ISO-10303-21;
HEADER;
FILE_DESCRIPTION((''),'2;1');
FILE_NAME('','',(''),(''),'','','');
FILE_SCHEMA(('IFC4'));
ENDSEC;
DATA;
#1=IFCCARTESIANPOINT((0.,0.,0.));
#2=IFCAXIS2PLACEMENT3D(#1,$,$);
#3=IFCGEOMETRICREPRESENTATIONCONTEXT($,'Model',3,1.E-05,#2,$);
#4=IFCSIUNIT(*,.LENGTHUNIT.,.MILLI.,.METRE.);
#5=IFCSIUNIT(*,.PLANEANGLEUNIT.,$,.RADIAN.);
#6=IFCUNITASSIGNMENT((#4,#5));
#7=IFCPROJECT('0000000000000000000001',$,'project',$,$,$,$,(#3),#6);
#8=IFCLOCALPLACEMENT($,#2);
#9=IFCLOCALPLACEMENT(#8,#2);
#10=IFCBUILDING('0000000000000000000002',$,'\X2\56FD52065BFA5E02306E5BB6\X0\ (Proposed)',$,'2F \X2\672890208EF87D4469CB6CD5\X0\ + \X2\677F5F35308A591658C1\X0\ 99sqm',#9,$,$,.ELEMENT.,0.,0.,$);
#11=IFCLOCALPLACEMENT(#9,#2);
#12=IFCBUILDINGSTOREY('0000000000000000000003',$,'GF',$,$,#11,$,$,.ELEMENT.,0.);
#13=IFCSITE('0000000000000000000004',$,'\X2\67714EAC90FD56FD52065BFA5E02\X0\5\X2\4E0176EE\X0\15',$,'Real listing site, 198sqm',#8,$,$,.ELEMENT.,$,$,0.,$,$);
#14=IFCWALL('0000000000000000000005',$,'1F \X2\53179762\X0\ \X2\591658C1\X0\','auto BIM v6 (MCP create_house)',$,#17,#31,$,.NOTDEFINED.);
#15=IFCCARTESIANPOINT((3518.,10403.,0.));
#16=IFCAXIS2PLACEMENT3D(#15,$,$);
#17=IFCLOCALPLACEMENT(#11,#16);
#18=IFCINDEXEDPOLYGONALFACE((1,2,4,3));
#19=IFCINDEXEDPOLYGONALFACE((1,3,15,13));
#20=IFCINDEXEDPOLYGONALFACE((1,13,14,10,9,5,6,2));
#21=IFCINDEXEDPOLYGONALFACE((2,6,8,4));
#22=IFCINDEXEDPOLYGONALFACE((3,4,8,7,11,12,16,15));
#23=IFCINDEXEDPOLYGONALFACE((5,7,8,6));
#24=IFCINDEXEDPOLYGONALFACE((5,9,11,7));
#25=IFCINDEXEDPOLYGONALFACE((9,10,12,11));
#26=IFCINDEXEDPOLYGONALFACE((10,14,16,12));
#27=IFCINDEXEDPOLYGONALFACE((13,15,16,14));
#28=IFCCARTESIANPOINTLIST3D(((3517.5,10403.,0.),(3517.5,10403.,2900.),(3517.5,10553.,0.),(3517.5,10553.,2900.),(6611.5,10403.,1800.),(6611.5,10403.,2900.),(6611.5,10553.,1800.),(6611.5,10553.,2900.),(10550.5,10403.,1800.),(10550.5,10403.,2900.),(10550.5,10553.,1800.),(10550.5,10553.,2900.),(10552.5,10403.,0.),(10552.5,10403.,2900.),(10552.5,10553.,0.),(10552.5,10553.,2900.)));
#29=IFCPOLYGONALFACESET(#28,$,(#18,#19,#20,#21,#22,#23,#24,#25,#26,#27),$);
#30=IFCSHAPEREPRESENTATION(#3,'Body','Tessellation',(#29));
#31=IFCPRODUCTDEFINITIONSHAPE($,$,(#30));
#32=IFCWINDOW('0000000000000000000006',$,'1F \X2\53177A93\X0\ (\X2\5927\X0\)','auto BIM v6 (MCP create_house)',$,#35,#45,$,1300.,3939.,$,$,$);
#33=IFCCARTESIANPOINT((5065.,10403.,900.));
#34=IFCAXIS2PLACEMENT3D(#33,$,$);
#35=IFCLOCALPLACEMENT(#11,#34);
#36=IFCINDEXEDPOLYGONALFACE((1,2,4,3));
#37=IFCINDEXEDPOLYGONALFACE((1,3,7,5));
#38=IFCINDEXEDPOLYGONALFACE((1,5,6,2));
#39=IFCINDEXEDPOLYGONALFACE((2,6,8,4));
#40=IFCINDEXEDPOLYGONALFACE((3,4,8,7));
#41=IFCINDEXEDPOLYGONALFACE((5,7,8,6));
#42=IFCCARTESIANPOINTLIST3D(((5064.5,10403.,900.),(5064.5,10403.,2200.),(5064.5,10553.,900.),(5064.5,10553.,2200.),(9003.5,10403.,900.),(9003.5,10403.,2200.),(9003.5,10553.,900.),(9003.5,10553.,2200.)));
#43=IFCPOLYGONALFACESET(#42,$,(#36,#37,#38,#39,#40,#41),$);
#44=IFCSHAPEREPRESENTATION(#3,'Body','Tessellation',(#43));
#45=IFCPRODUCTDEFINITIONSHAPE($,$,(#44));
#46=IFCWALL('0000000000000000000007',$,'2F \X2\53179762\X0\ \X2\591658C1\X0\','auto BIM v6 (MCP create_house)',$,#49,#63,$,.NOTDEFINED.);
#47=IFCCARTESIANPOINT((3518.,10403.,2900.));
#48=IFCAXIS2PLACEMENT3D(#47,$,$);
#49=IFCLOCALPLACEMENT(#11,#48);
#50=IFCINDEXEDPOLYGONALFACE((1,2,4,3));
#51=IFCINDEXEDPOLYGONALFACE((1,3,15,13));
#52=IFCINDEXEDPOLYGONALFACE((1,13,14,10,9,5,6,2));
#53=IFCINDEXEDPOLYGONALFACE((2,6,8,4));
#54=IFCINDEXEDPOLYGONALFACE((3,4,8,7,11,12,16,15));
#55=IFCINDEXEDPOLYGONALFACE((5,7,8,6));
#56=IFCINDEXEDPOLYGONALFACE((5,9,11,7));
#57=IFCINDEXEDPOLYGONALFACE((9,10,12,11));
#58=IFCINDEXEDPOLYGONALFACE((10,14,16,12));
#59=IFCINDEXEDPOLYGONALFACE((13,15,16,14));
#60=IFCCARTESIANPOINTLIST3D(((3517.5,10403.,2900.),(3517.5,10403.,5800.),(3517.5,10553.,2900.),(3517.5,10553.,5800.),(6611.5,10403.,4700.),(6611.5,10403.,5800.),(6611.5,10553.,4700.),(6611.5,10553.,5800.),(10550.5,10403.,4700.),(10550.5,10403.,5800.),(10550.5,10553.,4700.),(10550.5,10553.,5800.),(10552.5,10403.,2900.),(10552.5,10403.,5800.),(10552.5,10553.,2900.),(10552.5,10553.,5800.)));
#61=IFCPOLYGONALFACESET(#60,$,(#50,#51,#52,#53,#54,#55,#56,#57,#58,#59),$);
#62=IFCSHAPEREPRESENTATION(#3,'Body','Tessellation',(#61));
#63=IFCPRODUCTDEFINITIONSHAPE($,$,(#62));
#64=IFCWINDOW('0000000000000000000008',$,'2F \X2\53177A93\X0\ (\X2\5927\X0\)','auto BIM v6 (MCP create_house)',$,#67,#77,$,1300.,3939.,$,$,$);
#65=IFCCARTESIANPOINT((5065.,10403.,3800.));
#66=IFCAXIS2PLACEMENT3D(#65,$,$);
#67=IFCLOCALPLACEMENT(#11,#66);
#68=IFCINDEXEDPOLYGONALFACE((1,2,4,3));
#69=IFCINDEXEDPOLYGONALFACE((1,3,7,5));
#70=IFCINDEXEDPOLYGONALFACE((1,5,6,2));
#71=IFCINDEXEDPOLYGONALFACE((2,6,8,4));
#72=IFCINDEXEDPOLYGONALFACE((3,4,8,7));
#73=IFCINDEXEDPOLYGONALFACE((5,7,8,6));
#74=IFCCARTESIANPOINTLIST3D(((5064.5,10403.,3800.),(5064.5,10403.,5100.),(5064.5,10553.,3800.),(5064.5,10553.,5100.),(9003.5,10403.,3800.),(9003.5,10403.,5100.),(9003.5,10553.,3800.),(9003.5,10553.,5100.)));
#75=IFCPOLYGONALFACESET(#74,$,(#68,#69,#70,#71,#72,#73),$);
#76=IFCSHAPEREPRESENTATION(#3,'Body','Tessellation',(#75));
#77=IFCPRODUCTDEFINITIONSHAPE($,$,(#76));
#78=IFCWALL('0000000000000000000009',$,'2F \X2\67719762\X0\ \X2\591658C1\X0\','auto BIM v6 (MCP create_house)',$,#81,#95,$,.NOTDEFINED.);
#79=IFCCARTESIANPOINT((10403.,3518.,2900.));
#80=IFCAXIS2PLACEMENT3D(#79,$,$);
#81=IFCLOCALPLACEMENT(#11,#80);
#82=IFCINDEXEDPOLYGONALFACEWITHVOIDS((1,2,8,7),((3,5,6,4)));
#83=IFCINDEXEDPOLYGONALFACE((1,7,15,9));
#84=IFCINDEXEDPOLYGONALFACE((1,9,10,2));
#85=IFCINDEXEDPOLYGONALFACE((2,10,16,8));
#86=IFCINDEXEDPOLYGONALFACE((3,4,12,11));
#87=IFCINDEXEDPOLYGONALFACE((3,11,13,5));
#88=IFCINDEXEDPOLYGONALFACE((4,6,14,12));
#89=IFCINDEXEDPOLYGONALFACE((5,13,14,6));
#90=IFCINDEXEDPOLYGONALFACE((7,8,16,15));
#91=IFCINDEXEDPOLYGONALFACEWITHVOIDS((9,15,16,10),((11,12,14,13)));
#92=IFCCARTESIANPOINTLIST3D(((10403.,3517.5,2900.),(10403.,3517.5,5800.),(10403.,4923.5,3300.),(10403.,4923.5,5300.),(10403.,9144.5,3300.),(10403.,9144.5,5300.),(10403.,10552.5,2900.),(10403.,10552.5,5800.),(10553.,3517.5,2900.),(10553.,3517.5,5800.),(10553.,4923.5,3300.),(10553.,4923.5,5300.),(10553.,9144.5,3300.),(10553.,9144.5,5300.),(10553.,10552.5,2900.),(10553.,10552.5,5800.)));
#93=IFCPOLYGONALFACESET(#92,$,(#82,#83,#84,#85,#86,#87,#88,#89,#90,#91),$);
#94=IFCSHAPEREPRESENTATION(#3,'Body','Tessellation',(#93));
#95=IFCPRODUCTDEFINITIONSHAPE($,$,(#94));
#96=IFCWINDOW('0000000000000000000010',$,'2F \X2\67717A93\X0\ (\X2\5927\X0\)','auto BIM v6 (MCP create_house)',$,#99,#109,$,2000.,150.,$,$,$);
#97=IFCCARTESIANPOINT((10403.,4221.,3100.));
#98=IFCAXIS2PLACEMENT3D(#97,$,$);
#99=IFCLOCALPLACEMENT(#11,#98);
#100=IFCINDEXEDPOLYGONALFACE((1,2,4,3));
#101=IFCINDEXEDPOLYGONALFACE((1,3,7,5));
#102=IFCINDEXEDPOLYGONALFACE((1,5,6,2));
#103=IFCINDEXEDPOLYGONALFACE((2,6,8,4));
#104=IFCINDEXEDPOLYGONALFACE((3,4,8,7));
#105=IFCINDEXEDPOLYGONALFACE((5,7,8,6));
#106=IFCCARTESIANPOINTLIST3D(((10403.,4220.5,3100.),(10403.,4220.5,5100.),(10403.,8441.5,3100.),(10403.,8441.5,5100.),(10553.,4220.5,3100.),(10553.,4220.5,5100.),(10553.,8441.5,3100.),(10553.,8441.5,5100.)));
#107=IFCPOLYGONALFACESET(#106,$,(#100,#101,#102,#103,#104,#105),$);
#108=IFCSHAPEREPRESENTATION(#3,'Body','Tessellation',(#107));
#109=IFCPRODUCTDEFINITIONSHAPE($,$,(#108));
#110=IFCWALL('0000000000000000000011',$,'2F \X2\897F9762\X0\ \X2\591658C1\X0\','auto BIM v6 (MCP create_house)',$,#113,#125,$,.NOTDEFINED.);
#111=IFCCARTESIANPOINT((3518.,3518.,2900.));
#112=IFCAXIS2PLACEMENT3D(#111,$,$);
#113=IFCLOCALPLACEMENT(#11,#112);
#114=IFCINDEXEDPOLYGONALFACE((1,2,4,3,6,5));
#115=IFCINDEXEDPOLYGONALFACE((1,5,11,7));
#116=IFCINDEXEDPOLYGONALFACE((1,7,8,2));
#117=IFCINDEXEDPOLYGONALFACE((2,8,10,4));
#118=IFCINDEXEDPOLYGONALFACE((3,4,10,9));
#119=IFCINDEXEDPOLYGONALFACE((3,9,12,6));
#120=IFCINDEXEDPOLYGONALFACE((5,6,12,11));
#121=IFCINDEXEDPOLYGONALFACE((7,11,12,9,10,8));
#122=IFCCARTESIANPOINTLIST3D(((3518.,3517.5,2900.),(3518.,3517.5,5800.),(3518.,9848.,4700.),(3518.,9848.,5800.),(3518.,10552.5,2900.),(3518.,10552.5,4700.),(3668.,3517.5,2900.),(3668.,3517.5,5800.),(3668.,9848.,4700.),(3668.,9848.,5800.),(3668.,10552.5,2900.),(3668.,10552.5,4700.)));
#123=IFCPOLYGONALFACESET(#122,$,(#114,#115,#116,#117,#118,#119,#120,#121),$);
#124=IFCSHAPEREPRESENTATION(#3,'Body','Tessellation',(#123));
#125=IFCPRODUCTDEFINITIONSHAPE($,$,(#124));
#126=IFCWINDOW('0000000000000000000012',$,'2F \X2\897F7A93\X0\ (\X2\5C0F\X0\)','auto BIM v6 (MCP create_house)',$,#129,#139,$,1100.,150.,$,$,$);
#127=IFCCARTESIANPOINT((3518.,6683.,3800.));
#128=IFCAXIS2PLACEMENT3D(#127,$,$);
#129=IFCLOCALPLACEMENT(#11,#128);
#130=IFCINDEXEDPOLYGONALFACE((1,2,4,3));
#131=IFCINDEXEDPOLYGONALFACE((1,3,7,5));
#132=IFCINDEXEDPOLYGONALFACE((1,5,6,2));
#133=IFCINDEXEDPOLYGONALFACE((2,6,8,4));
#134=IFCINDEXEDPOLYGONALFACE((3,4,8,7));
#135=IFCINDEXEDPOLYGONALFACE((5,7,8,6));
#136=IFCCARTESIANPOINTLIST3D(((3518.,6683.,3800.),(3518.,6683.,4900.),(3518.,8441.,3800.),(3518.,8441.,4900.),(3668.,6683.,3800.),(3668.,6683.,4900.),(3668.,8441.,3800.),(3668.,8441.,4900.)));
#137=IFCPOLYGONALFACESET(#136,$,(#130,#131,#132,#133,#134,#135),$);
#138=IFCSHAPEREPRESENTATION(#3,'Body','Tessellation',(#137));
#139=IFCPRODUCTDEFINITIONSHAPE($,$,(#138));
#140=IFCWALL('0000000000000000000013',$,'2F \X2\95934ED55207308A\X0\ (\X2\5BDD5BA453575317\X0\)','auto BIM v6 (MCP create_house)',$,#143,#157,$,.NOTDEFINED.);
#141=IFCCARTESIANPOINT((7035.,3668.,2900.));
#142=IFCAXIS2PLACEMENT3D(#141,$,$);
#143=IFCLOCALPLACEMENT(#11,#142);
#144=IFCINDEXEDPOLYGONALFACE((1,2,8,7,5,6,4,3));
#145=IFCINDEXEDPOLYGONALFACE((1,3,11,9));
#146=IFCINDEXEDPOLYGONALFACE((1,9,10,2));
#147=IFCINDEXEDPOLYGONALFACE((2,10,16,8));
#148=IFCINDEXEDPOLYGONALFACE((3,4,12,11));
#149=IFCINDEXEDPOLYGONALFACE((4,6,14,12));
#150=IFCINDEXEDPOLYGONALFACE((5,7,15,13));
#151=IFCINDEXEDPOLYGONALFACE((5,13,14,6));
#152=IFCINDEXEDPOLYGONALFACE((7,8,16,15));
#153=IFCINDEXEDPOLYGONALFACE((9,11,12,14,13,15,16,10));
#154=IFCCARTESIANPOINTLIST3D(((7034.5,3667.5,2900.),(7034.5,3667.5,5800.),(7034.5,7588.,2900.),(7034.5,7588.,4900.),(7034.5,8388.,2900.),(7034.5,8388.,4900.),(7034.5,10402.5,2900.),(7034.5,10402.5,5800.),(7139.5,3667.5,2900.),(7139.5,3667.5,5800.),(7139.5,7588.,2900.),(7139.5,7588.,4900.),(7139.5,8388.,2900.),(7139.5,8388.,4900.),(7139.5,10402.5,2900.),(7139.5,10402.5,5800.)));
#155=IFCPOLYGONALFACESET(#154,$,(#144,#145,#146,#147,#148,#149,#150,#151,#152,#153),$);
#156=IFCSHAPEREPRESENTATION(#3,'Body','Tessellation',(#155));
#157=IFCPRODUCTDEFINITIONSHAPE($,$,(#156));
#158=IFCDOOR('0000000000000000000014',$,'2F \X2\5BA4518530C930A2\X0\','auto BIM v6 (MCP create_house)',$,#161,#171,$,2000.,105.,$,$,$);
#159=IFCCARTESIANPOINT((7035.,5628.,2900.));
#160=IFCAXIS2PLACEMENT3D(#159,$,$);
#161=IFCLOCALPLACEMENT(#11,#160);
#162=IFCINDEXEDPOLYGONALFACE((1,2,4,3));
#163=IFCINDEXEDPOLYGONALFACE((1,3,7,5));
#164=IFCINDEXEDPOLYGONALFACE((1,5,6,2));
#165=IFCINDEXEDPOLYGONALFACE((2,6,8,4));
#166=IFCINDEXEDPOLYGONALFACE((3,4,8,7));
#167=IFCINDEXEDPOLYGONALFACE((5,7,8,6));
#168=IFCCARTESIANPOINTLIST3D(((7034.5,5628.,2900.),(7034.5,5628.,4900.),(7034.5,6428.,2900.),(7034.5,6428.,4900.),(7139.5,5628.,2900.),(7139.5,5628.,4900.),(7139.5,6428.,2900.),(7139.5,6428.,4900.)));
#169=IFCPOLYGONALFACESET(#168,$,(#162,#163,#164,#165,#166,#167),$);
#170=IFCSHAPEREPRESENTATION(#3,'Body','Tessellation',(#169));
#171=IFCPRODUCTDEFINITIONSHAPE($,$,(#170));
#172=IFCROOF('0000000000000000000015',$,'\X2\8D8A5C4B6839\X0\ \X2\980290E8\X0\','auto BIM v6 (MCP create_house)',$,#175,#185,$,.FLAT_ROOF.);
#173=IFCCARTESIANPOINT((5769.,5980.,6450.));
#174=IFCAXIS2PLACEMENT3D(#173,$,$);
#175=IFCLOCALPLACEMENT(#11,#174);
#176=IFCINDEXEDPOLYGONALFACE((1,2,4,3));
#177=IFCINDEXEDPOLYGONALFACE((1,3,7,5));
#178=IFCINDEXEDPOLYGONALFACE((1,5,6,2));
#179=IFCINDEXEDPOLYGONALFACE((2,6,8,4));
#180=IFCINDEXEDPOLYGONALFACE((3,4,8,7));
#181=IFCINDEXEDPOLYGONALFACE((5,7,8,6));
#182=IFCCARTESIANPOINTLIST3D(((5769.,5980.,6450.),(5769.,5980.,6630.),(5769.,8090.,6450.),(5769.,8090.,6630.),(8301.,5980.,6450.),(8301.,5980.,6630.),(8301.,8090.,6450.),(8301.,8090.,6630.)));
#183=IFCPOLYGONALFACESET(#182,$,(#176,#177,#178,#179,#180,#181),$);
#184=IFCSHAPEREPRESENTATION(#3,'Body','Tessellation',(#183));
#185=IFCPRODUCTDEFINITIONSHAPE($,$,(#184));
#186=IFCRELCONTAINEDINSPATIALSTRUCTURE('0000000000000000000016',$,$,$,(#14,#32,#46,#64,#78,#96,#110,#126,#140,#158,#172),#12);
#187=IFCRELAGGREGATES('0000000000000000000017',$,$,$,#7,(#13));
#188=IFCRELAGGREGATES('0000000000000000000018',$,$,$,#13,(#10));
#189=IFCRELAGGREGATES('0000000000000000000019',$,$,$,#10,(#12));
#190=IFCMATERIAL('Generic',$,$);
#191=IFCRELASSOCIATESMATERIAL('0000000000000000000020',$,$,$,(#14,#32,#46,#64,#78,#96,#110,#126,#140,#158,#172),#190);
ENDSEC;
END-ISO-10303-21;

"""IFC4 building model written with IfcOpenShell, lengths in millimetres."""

from ifc_helpers import new_model, si_unit, frame, frame_2d, origin, place, context, project, spatial, rectangle, extrude, material, element, fill, save


model = new_model("IFC4")

# Units and contexts
model_context = context("Model", 3, precision=1e-05, world=origin())
ifc_project = project(units=[si_unit("LENGTHUNIT", "METRE", prefix="MILLI"), si_unit("PLANEANGLEUNIT", "RADIAN")], contexts=[model_context])

# Site, building, storey
site_placement = place(None, origin())
site = spatial("IfcSite", under=ifc_project, at=site_placement, Name="東京都国分寺市5丁目15", ObjectType="Real listing site, 198sqm", CompositionType="ELEMENT", RefElevation=0.0)
building_placement = place(site_placement, origin())
building = spatial("IfcBuilding", under=site, at=building_placement, Name="国分寺市の家 (Proposed)", ObjectType="2F 木造軸組構法 + 板張り外壁 99sqm", CompositionType="ELEMENT", ElevationOfRefHeight=0.0, ElevationOfTerrain=0.0)
storey_placement = place(building_placement, origin())
storey = spatial("IfcBuildingStorey", under=building, at=storey_placement, Name="GF", CompositionType="ELEMENT", Elevation=0.0)

# Wall, opening, window
ifc_material = material(Name="Generic")
wall_1_placement = place(storey_placement, frame((3518.0, 10403.0, 0.0)))
wall_1 = element("IfcWall", 1, at=wall_1_placement, inside=storey, material=ifc_material, Name="1F 北面 外壁", Description="auto BIM v6 (MCP create_house)", PredefinedType="NOTDEFINED", context=model_context, shape_type="SweptSolid", body=[
    extrude(rectangle(XDim=7035.0, YDim=150.0, at=frame_2d((3517.0, 75.0))), frame((3518.0, 10403.0, 0.0)), (0.0, 0.0, 1.0), 2900.0),
])
opening_1_placement = place(storey_placement, frame((5065.0, 10403.0, 900.0)))
opening_1 = element("IfcOpeningElement", 2, at=opening_1_placement, cuts=wall_1, PredefinedType="NOTDEFINED", context=model_context, shape_type="SweptSolid", body=[
    extrude(rectangle(XDim=3939.0, YDim=150.0, at=frame_2d((1969.0, 75.0))), frame((5065.0, 10403.0, 900.0)), (0.0, 0.0, 1.0), 1300.0),
])
window_1_placement = place(storey_placement, frame((5065.0, 10403.0, 900.0)))
window_1 = element("IfcWindow", 3, at=window_1_placement, inside=storey, material=ifc_material, Name="1F 北窓 (大)", Description="auto BIM v6 (MCP create_house)", OverallHeight=1300.0, OverallWidth=3939.0, context=model_context, shape_type="SweptSolid", body=[
    extrude(rectangle(XDim=3939.0, YDim=150.0, at=frame_2d((1969.0, 75.0))), frame((5065.0, 10403.0, 900.0)), (0.0, 0.0, 1.0), 1300.0),
])
fill(opening_1, window_1)

# Walls, openings, windows
wall_2_placement = place(storey_placement, frame((3518.0, 10403.0, 2900.0)))
wall_2 = element("IfcWall", 4, at=wall_2_placement, inside=storey, material=ifc_material, Name="2F 北面 外壁", Description="auto BIM v6 (MCP create_house)", PredefinedType="NOTDEFINED", context=model_context, shape_type="SweptSolid", body=[
    extrude(rectangle(XDim=7035.0, YDim=150.0, at=frame_2d((3517.0, 75.0))), frame((3518.0, 10403.0, 2900.0)), (0.0, 0.0, 1.0), 2900.0),
])
opening_2_placement = place(storey_placement, frame((5065.0, 10403.0, 3800.0)))
opening_2 = element("IfcOpeningElement", 5, at=opening_2_placement, cuts=wall_2, PredefinedType="NOTDEFINED", context=model_context, shape_type="SweptSolid", body=[
    extrude(rectangle(XDim=3939.0, YDim=150.0, at=frame_2d((1969.0, 75.0))), frame((5065.0, 10403.0, 3800.0)), (0.0, 0.0, 1.0), 1300.0),
])
window_2_placement = place(storey_placement, frame((5065.0, 10403.0, 3800.0)))
window_2 = element("IfcWindow", 6, at=window_2_placement, inside=storey, material=ifc_material, Name="2F 北窓 (大)", Description="auto BIM v6 (MCP create_house)", OverallHeight=1300.0, OverallWidth=3939.0, context=model_context, shape_type="SweptSolid", body=[
    extrude(rectangle(XDim=3939.0, YDim=150.0, at=frame_2d((1969.0, 75.0))), frame((5065.0, 10403.0, 3800.0)), (0.0, 0.0, 1.0), 1300.0),
])
fill(opening_2, window_2)
wall_3_placement = place(storey_placement, frame((10403.0, 3518.0, 2900.0)))
wall_3 = element("IfcWall", 7, at=wall_3_placement, inside=storey, material=ifc_material, Name="2F 東面 外壁", Description="auto BIM v6 (MCP create_house)", PredefinedType="NOTDEFINED", context=model_context, shape_type="SweptSolid", body=[
    extrude(rectangle(XDim=150.0, YDim=7035.0, at=frame_2d((75.0, 3517.0))), frame((10403.0, 3518.0, 2900.0)), (0.0, 0.0, 1.0), 2900.0),
])
opening_3_placement = place(storey_placement, frame((10403.0, 4221.0, 3100.0)))
opening_3 = element("IfcOpeningElement", 8, at=opening_3_placement, cuts=wall_3, PredefinedType="NOTDEFINED", context=model_context, shape_type="SweptSolid", body=[
    extrude(rectangle(XDim=150.0, YDim=4221.0, at=frame_2d((75.0, 2110.0))), frame((10403.0, 4221.0, 3100.0)), (0.0, 0.0, 1.0), 2000.0),
])
window_3_placement = place(storey_placement, frame((10403.0, 4221.0, 3100.0)))
window_3 = element("IfcWindow", 9, at=window_3_placement, inside=storey, material=ifc_material, Name="2F 東窓 (大)", Description="auto BIM v6 (MCP create_house)", OverallHeight=2000.0, OverallWidth=150.0, context=model_context, shape_type="SweptSolid", body=[
    extrude(rectangle(XDim=150.0, YDim=4221.0, at=frame_2d((75.0, 2110.0))), frame((10403.0, 4221.0, 3100.0)), (0.0, 0.0, 1.0), 2000.0),
])
fill(opening_3, window_3)
wall_4_placement = place(storey_placement, frame((3518.0, 3518.0, 2900.0)))
wall_4 = element("IfcWall", 10, at=wall_4_placement, inside=storey, material=ifc_material, Name="2F 西面 外壁", Description="auto BIM v6 (MCP create_house)", PredefinedType="NOTDEFINED", context=model_context, shape_type="SweptSolid", body=[
    extrude(rectangle(XDim=150.0, YDim=7035.0, at=frame_2d((75.0, 3517.0))), frame((3518.0, 3518.0, 2900.0)), (0.0, 0.0, 1.0), 2900.0),
])
opening_4_placement = place(storey_placement, frame((3518.0, 6683.0, 3800.0)))
opening_4 = element("IfcOpeningElement", 11, at=opening_4_placement, cuts=wall_4, PredefinedType="NOTDEFINED", context=model_context, shape_type="SweptSolid", body=[
    extrude(rectangle(XDim=150.0, YDim=1758.0, at=frame_2d((75.0, 879.0))), frame((3518.0, 6683.0, 3800.0)), (0.0, 0.0, 1.0), 1100.0),
])
window_4_placement = place(storey_placement, frame((3518.0, 6683.0, 3800.0)))
window_4 = element("IfcWindow", 12, at=window_4_placement, inside=storey, material=ifc_material, Name="2F 西窓 (小)", Description="auto BIM v6 (MCP create_house)", OverallHeight=1100.0, OverallWidth=150.0, context=model_context, shape_type="SweptSolid", body=[
    extrude(rectangle(XDim=150.0, YDim=1758.0, at=frame_2d((75.0, 879.0))), frame((3518.0, 6683.0, 3800.0)), (0.0, 0.0, 1.0), 1100.0),
])
fill(opening_4, window_4)

# Wall, opening, door
wall_5_placement = place(storey_placement, frame((7035.0, 3668.0, 2900.0)))
wall_5 = element("IfcWall", 13, at=wall_5_placement, inside=storey, material=ifc_material, Name="2F 間仕切り (寝室南北)", Description="auto BIM v6 (MCP create_house)", PredefinedType="NOTDEFINED", context=model_context, shape_type="SweptSolid", body=[
    extrude(rectangle(XDim=105.0, YDim=6735.0, at=frame_2d((52.0, 3367.0))), frame((7035.0, 3668.0, 2900.0)), (0.0, 0.0, 1.0), 2900.0),
])
opening_5_placement = place(storey_placement, frame((7035.0, 5628.0, 2900.0)))
opening_5 = element("IfcOpeningElement", 14, at=opening_5_placement, cuts=wall_5, PredefinedType="NOTDEFINED", context=model_context, shape_type="SweptSolid", body=[
    extrude(rectangle(XDim=105.0, YDim=800.0, at=frame_2d((52.0, 400.0))), frame((7035.0, 5628.0, 2900.0)), (0.0, 0.0, 1.0), 2000.0),
])
door_placement = place(storey_placement, frame((7035.0, 5628.0, 2900.0)))
door = element("IfcDoor", 15, at=door_placement, inside=storey, material=ifc_material, Name="2F 室内ドア", Description="auto BIM v6 (MCP create_house)", OverallHeight=2000.0, OverallWidth=105.0, context=model_context, shape_type="SweptSolid", body=[
    extrude(rectangle(XDim=105.0, YDim=800.0, at=frame_2d((52.0, 400.0))), frame((7035.0, 5628.0, 2900.0)), (0.0, 0.0, 1.0), 2000.0),
])
fill(opening_5, door)

# Roof
roof_placement = place(storey_placement, frame((5769.0, 5980.0, 6450.0)))
element("IfcRoof", 16, at=roof_placement, inside=storey, material=ifc_material, Name="越屋根 頂部", Description="auto BIM v6 (MCP create_house)", PredefinedType="FLAT_ROOF", context=model_context, shape_type="SweptSolid", body=[
    extrude(rectangle(XDim=2532.0, YDim=2110.0, at=frame_2d((1266.0, 1055.0))), frame((5769.0, 5980.0, 6450.0)), (0.0, 0.0, 1.0), 180.0),
])

save(model, "model.ifc")
